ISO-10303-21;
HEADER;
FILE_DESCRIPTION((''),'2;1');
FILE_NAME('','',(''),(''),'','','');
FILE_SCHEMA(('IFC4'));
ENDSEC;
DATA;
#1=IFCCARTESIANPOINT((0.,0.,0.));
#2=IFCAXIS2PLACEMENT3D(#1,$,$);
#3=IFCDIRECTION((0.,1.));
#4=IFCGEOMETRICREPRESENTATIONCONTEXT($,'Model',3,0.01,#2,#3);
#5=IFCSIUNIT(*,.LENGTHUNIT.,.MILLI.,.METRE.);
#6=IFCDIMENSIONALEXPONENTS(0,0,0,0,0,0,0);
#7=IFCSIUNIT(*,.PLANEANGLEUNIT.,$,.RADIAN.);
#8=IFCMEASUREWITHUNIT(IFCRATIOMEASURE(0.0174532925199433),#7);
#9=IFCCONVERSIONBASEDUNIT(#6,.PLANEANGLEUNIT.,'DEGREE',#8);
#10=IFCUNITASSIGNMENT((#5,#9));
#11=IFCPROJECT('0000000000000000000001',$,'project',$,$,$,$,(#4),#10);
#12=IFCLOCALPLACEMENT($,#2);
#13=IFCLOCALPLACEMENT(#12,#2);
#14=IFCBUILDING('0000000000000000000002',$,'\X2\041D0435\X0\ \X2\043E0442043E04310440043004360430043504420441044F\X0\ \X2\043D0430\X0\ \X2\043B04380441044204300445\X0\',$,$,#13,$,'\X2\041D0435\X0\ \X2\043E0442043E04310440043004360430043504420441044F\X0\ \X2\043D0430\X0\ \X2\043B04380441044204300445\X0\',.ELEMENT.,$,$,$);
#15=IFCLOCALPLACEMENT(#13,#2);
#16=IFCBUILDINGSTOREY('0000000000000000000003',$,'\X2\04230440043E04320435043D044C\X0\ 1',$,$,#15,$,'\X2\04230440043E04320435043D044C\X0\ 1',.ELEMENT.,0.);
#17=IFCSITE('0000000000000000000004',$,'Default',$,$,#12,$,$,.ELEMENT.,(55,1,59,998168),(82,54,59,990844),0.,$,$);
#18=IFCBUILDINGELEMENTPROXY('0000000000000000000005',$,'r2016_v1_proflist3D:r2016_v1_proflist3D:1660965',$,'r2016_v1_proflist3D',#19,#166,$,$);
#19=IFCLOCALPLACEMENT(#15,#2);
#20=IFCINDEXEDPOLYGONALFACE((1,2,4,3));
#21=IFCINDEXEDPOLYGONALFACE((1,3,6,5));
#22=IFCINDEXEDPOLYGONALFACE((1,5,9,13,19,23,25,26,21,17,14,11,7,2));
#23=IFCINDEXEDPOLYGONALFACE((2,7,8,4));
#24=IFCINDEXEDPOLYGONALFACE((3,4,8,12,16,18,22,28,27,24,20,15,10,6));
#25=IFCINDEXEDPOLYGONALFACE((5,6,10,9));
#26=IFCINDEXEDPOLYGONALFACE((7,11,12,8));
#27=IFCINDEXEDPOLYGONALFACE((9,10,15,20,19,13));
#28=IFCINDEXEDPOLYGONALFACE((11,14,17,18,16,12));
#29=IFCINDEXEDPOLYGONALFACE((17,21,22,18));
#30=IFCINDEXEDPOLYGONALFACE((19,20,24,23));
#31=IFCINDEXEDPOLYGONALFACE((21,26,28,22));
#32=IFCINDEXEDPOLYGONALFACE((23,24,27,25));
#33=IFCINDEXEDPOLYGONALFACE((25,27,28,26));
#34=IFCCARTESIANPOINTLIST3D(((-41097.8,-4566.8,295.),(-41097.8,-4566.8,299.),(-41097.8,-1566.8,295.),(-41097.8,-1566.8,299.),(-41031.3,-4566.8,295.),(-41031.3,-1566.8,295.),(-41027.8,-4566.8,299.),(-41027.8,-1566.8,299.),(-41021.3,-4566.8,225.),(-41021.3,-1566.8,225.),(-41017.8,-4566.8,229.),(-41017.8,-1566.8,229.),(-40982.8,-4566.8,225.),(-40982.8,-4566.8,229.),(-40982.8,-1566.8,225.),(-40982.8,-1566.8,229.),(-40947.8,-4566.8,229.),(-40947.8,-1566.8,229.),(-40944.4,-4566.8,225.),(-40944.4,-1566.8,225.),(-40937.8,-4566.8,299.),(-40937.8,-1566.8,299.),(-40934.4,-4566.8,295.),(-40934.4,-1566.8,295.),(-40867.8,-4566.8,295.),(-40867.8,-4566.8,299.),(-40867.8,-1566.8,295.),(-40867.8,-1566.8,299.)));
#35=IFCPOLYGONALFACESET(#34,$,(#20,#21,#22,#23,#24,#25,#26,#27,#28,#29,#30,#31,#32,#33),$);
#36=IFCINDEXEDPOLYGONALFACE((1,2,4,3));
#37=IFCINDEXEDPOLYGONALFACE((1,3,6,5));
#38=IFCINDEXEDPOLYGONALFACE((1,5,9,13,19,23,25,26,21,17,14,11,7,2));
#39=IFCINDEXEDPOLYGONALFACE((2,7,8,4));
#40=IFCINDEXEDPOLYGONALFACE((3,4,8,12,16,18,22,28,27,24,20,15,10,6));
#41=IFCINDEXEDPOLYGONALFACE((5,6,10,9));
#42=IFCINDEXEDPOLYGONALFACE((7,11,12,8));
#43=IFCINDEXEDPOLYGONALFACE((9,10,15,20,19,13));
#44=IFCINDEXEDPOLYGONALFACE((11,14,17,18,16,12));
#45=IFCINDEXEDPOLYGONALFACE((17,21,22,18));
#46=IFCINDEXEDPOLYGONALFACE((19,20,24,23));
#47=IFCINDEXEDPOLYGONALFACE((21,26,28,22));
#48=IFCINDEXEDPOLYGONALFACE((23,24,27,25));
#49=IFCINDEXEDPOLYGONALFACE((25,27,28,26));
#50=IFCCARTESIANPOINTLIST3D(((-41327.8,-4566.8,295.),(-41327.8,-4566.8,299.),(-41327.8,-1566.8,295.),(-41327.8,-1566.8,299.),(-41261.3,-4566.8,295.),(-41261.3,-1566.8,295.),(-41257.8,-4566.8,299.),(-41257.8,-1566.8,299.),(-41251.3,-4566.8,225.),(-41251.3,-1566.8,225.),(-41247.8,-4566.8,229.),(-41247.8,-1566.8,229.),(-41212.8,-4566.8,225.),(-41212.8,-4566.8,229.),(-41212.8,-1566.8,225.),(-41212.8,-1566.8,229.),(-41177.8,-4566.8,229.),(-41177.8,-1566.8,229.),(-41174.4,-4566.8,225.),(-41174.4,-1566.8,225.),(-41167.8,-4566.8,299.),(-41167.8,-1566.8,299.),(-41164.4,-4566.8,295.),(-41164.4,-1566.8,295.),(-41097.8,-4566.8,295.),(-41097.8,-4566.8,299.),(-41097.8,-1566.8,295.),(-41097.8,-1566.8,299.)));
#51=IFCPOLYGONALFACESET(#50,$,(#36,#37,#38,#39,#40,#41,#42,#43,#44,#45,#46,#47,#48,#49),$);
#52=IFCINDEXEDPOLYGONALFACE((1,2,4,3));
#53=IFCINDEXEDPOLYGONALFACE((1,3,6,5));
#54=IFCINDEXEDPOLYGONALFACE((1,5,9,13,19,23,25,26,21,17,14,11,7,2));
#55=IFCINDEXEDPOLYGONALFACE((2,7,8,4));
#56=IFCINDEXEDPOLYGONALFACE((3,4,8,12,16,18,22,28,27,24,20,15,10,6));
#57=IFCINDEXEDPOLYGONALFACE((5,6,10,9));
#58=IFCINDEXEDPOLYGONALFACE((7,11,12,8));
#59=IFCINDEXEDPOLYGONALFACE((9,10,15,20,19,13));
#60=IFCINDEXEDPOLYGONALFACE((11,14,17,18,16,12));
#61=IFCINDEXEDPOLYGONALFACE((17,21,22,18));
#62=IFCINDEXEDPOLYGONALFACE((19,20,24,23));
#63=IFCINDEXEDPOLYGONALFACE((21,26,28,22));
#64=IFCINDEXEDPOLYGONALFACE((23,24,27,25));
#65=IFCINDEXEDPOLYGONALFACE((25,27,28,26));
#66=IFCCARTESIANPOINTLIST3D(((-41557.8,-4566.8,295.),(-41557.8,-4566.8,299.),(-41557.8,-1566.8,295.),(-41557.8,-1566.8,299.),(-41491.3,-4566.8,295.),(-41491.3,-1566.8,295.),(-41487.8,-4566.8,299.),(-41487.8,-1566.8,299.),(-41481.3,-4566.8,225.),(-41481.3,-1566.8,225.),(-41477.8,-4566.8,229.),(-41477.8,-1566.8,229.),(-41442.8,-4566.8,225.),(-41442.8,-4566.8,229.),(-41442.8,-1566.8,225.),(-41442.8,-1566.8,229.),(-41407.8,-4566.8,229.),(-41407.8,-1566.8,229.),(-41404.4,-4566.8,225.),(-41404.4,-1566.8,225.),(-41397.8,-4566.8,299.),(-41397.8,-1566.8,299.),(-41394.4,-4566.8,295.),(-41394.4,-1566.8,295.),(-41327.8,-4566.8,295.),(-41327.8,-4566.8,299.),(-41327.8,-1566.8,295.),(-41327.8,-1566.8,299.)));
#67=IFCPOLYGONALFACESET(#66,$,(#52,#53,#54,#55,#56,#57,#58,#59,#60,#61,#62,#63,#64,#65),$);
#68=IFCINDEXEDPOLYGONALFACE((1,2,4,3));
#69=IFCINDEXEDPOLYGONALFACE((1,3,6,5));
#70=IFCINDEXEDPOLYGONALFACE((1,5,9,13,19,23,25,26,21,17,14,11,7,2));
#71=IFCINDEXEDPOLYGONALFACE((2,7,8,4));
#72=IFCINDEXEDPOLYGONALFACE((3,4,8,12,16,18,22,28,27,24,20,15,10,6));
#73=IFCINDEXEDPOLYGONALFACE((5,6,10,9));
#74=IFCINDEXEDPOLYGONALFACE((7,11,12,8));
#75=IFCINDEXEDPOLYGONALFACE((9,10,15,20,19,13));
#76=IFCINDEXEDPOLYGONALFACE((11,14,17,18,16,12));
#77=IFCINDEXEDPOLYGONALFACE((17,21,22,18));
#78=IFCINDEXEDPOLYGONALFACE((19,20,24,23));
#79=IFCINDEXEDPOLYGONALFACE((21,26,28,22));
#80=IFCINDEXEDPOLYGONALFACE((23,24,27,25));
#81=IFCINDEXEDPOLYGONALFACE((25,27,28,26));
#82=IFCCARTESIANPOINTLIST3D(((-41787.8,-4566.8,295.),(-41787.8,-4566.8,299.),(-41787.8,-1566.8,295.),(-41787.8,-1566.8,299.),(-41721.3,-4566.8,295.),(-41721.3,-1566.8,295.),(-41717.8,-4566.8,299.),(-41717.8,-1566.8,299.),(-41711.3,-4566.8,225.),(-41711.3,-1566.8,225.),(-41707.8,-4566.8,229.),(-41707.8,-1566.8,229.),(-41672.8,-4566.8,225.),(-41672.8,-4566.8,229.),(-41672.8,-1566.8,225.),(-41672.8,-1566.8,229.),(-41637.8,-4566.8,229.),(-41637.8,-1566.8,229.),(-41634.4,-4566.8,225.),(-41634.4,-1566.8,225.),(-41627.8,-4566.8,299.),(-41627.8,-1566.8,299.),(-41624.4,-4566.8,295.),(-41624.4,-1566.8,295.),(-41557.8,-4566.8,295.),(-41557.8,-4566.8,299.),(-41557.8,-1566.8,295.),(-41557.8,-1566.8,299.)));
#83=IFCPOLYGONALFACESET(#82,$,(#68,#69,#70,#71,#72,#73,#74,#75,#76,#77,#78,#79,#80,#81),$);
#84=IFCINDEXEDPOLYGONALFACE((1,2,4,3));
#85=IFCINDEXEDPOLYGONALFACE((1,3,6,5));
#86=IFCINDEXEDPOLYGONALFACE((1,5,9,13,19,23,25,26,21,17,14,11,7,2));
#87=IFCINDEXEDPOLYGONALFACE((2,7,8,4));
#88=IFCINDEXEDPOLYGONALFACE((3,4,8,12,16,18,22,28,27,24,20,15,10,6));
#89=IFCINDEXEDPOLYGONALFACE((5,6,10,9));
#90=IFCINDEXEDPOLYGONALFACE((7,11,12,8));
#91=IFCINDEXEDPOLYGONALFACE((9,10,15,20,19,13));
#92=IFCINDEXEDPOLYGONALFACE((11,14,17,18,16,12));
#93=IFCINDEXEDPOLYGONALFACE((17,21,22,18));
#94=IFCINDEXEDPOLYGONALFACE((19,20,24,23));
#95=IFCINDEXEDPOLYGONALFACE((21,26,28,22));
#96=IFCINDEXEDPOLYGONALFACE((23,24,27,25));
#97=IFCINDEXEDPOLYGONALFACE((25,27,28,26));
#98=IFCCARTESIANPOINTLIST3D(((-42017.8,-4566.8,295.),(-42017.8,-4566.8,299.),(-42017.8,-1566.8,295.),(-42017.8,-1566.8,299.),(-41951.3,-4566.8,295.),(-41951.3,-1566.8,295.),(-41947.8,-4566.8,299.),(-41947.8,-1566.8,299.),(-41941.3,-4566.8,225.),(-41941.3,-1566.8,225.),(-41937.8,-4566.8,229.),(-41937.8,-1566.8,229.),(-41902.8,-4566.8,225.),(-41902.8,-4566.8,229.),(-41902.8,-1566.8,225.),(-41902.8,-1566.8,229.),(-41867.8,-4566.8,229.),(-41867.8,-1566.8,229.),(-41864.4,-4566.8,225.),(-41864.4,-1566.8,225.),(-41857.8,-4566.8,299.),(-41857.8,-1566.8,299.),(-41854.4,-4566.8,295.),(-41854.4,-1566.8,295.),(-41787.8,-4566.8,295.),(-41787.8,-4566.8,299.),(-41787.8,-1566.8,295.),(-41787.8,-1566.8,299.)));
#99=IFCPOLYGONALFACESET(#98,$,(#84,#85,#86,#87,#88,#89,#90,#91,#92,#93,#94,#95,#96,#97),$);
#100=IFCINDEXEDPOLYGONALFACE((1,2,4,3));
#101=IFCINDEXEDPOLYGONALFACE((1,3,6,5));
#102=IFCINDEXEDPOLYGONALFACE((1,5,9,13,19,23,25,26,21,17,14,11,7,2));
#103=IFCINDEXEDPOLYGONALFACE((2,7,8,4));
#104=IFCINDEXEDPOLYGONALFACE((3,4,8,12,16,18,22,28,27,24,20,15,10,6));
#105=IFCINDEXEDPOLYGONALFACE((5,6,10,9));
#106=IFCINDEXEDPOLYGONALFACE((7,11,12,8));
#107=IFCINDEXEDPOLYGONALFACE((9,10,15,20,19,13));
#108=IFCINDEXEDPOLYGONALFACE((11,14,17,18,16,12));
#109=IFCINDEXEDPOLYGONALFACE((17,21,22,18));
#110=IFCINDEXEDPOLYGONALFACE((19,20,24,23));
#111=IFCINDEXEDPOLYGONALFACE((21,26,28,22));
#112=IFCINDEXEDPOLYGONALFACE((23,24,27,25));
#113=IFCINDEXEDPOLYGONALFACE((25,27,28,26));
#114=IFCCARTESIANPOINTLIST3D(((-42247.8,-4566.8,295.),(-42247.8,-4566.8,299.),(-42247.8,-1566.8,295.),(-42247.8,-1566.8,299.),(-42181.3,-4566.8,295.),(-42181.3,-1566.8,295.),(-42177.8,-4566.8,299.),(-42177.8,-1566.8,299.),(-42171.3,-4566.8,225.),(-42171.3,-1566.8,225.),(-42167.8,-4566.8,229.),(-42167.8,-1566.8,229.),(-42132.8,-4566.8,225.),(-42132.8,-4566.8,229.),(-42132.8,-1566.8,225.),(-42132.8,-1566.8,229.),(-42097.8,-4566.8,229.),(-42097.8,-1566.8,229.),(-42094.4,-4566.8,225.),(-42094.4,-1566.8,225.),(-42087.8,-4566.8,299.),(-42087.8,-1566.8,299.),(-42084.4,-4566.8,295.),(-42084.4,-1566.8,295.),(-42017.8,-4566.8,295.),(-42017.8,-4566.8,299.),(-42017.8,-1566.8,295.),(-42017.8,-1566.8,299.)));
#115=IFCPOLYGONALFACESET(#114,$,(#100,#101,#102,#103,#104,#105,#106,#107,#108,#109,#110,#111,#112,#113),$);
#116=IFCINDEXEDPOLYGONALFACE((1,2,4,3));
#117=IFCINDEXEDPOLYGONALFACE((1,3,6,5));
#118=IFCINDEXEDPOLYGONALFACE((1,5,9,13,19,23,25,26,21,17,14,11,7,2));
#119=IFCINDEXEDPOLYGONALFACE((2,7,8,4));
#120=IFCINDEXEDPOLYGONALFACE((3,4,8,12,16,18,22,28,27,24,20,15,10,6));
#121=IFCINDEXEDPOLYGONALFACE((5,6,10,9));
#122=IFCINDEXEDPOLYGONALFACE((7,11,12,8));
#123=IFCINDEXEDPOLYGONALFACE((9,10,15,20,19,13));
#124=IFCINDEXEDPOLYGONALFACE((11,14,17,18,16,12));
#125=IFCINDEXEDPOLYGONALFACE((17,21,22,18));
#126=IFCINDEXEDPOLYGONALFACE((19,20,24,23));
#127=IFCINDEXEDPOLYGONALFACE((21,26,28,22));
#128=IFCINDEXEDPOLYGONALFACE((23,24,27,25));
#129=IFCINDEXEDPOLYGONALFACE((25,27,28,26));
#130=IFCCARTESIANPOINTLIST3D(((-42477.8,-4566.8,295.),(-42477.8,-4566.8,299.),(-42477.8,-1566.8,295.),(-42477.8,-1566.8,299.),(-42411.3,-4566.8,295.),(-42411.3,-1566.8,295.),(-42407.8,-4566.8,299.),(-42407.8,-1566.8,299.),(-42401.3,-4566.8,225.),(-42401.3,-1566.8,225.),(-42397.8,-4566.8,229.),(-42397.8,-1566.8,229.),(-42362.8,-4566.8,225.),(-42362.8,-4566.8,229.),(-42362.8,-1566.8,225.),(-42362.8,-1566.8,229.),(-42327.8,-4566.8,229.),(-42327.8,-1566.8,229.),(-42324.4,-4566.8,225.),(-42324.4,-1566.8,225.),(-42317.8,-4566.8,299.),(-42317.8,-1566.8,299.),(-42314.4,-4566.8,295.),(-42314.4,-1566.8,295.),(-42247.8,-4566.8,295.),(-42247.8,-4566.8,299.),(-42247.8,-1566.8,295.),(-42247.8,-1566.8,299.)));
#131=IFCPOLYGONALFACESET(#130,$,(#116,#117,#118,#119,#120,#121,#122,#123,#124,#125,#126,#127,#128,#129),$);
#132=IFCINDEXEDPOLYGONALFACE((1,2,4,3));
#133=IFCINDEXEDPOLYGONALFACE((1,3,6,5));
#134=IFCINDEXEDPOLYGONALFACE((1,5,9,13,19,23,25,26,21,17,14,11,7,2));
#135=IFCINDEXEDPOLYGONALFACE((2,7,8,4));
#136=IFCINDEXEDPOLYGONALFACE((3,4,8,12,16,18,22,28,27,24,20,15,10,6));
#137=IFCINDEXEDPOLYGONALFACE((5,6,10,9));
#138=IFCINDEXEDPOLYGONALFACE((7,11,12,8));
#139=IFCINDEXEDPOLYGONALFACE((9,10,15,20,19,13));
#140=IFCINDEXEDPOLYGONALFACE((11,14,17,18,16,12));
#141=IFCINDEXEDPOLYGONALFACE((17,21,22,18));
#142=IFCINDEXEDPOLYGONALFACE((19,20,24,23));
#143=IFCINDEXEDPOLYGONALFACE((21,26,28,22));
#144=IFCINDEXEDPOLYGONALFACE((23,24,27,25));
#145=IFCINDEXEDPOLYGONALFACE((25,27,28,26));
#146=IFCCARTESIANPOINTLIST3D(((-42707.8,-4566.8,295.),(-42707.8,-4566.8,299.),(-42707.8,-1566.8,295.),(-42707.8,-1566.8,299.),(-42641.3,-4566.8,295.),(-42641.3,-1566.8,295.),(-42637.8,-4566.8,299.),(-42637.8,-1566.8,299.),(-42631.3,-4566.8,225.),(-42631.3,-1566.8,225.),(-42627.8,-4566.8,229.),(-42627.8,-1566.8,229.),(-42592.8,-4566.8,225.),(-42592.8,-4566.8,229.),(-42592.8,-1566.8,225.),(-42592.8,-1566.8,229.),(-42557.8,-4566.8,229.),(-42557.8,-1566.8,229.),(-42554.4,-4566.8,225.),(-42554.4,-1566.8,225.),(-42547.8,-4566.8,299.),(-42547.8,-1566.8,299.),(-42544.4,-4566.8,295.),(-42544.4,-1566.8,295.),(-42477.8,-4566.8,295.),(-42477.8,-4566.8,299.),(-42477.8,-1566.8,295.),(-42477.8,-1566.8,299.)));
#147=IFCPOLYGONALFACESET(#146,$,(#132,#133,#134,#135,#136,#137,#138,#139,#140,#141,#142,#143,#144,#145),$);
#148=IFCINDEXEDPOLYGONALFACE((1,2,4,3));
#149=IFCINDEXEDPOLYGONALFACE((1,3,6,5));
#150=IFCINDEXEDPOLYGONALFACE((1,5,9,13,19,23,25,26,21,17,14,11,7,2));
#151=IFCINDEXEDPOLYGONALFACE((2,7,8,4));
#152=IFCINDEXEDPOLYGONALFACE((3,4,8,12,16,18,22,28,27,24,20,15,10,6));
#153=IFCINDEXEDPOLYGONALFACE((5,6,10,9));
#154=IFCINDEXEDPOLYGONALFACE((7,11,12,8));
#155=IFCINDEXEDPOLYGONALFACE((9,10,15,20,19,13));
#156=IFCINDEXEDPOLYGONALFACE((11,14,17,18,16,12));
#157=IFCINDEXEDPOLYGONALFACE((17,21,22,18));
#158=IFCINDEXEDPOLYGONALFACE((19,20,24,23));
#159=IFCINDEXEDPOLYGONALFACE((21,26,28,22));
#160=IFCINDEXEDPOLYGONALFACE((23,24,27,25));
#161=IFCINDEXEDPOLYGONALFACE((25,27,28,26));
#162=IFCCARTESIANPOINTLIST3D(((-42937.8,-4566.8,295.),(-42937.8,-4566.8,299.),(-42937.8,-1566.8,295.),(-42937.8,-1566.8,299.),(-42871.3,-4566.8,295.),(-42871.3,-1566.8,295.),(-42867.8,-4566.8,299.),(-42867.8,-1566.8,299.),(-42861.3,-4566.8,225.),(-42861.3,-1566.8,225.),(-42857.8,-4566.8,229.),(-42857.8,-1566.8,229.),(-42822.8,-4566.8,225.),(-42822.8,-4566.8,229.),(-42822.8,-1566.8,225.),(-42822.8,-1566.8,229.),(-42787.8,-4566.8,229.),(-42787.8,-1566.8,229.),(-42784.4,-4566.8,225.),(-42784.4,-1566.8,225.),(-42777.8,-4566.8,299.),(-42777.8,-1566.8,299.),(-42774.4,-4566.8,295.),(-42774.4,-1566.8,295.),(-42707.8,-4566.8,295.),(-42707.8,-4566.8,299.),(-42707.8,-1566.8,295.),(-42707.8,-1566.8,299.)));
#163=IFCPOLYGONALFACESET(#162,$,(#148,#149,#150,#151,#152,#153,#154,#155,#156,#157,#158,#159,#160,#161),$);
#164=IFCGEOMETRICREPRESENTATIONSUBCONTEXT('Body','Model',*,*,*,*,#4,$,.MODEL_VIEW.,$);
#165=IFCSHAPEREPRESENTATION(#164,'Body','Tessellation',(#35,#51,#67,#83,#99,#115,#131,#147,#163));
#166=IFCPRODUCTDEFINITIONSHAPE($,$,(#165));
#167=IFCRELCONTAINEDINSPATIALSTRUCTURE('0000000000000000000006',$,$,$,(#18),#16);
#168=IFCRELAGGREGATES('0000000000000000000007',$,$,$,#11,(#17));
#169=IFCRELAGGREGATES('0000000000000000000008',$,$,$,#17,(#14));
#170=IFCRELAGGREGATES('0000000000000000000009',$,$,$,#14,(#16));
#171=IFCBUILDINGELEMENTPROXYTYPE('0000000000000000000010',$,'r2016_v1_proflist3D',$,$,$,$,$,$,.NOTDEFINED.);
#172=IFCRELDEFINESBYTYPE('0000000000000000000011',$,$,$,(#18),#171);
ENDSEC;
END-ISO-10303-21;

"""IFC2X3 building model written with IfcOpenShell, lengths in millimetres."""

from ifc_helpers import new_model, entity, si_unit, converted_unit, direction, frame, origin, place, context, subcontext, project, spatial, polyline, outline, extrude, source, transform, mapped, type_object, type_shapes, element, save


model = new_model("IFC2X3")

# Units and contexts
model_context = context("Model", 3, precision=0.01, world=origin(), true_north=direction((0.0, 1.0)))
body_context = subcontext(model_context, "Body", "Model", "MODEL_VIEW")
ifc_project = project(units=[si_unit("LENGTHUNIT", "METRE", prefix="MILLI"), converted_unit("PLANEANGLEUNIT", "DEGREE", entity("IfcRatioMeasure", 0.0174532925199433), si_unit("PLANEANGLEUNIT", "RADIAN"), dimensions=[0, 0, 0, 0, 0, 0, 0])], contexts=[model_context])

# Site, building, storey
site_placement = place(None, origin())
site = spatial("IfcSite", under=ifc_project, at=site_placement, Name="Default", CompositionType="ELEMENT", RefLatitude=(55, 1, 59, 998168), RefLongitude=(82, 54, 59, 990844), RefElevation=0.0)
building_placement = place(site_placement, origin())
building = spatial("IfcBuilding", under=site, at=building_placement, Name="Не отображается на листах", LongName="Не отображается на листах", CompositionType="ELEMENT")
storey_placement = place(building_placement, frame((0.0, 0.0, 0.0)))
storey = spatial("IfcBuildingStorey", under=building, at=storey_placement, Name="Уровень 1", LongName="Уровень 1", CompositionType="ELEMENT", Elevation=0.0)

# Building element proxy
building_element_proxy_type = type_object("IfcBuildingElementProxyType", Name="r2016_v1_proflist3D", PredefinedType="NOTDEFINED")
shared_shape = source(origin(), body_context, "Body", "SweptSolid", [
    extrude(outline(polyline([(-38.0, -40.0), (-47.9, -109.3), (-44.0, -109.9), (-34.6, -44.0), (36.1, -44.0), (41.6, -5.9), (47.0, 32.1), (-20.9, 51.9), (-11.5, 117.8), (-15.4, 118.4), (-25.3, 49.1), (42.6, 29.3), (37.6, -5.4), (32.7, -40.0), (-38.0, -40.0)])), frame((1955.0, -3000.0, -32.0), z_axis=(0.0, -1.0, 0.0), x_axis=(0.141421, 0.0, -0.989949)), (0.0, 0.0, -1.0), 3000.0),
    extrude(outline(polyline([(-38.0, -40.0), (-47.9, -109.3), (-44.0, -109.9), (-34.6, -44.0), (36.1, -44.0), (41.6, -5.9), (47.0, 32.1), (-20.9, 51.9), (-11.5, 117.8), (-15.4, 118.4), (-25.3, 49.1), (42.6, 29.3), (37.6, -5.4), (32.7, -40.0), (-38.0, -40.0)])), frame((1725.0, -3000.0, -32.0), z_axis=(0.0, -1.0, 0.0), x_axis=(0.141421, 0.0, -0.989949)), (0.0, 0.0, -1.0), 3000.0),
    extrude(outline(polyline([(-38.0, -40.0), (-47.9, -109.3), (-44.0, -109.9), (-34.6, -44.0), (36.1, -44.0), (41.6, -5.9), (47.0, 32.1), (-20.9, 51.9), (-11.5, 117.8), (-15.4, 118.4), (-25.3, 49.1), (42.6, 29.3), (37.6, -5.4), (32.7, -40.0), (-38.0, -40.0)])), frame((1495.0, -3000.0, -32.0), z_axis=(0.0, -1.0, 0.0), x_axis=(0.141421, 0.0, -0.989949)), (0.0, 0.0, -1.0), 3000.0),
    extrude(outline(polyline([(-38.0, -40.0), (-47.9, -109.3), (-44.0, -109.9), (-34.6, -44.0), (36.1, -44.0), (41.6, -5.9), (47.0, 32.1), (-20.9, 51.9), (-11.5, 117.8), (-15.4, 118.4), (-25.3, 49.1), (42.6, 29.3), (37.6, -5.4), (32.7, -40.0), (-38.0, -40.0)])), frame((1265.0, -3000.0, -32.0), z_axis=(0.0, -1.0, 0.0), x_axis=(0.141421, 0.0, -0.989949)), (0.0, 0.0, -1.0), 3000.0),
    extrude(outline(polyline([(-38.0, -40.0), (-47.9, -109.3), (-44.0, -109.9), (-34.6, -44.0), (36.1, -44.0), (41.6, -5.9), (47.0, 32.1), (-20.9, 51.9), (-11.5, 117.8), (-15.4, 118.4), (-25.3, 49.1), (42.6, 29.3), (37.6, -5.4), (32.7, -40.0), (-38.0, -40.0)])), frame((1035.0, -3000.0, -32.0), z_axis=(0.0, -1.0, 0.0), x_axis=(0.141421, 0.0, -0.989949)), (0.0, 0.0, -1.0), 3000.0),
    extrude(outline(polyline([(-38.0, -40.0), (-47.9, -109.3), (-44.0, -109.9), (-34.6, -44.0), (36.1, -44.0), (41.6, -5.9), (47.0, 32.1), (-20.9, 51.9), (-11.5, 117.8), (-15.4, 118.4), (-25.3, 49.1), (42.6, 29.3), (37.6, -5.4), (32.7, -40.0), (-38.0, -40.0)])), frame((805.0, -3000.0, -32.0), z_axis=(0.0, -1.0, 0.0), x_axis=(0.141421, 0.0, -0.989949)), (0.0, 0.0, -1.0), 3000.0),
    extrude(outline(polyline([(-38.0, -40.0), (-47.9, -109.3), (-44.0, -109.9), (-34.6, -44.0), (36.1, -44.0), (41.6, -5.9), (47.0, 32.1), (-20.9, 51.9), (-11.5, 117.8), (-15.4, 118.4), (-25.3, 49.1), (42.6, 29.3), (37.6, -5.4), (32.7, -40.0), (-38.0, -40.0)])), frame((575.0, -3000.0, -32.0), z_axis=(0.0, -1.0, 0.0), x_axis=(0.141421, 0.0, -0.989949)), (0.0, 0.0, -1.0), 3000.0),
    extrude(outline(polyline([(-38.0, -40.0), (-47.9, -109.3), (-44.0, -109.9), (-34.6, -44.0), (36.1, -44.0), (41.6, -5.9), (47.0, 32.1), (-20.9, 51.9), (-11.5, 117.8), (-15.4, 118.4), (-25.3, 49.1), (42.6, 29.3), (37.6, -5.4), (32.7, -40.0), (-38.0, -40.0)])), frame((345.0, -3000.0, -32.0), z_axis=(0.0, -1.0, 0.0), x_axis=(0.141421, 0.0, -0.989949)), (0.0, 0.0, -1.0), 3000.0),
    extrude(outline(polyline([(-38.0, -40.0), (-47.9, -109.3), (-44.0, -109.9), (-34.6, -44.0), (36.1, -44.0), (41.6, -5.9), (47.0, 32.1), (-20.9, 51.9), (-11.5, 117.8), (-15.4, 118.4), (-25.3, 49.1), (42.6, 29.3), (37.6, -5.4), (32.7, -40.0), (-38.0, -40.0)])), frame((115.0, -3000.0, -32.0), z_axis=(0.0, -1.0, 0.0), x_axis=(0.141421, 0.0, -0.989949)), (0.0, 0.0, -1.0), 3000.0),
])
type_shapes(building_element_proxy_type, [shared_shape])
proxy_1_placement = place(storey_placement, frame((-42937.8, -1566.8, 299.0)))
element("IfcBuildingElementProxy", 1, at=proxy_1_placement, inside=storey, type_object=building_element_proxy_type, Name="r2016_v1_proflist3D:r2016_v1_proflist3D:1660965", ObjectType="r2016_v1_proflist3D", context=body_context, shape_type="MappedRepresentation", body=[
    mapped(shared_shape, transform((0.0, 0.0, 0.0), scale=1.0)),
])

save(model, "model.ifc")
